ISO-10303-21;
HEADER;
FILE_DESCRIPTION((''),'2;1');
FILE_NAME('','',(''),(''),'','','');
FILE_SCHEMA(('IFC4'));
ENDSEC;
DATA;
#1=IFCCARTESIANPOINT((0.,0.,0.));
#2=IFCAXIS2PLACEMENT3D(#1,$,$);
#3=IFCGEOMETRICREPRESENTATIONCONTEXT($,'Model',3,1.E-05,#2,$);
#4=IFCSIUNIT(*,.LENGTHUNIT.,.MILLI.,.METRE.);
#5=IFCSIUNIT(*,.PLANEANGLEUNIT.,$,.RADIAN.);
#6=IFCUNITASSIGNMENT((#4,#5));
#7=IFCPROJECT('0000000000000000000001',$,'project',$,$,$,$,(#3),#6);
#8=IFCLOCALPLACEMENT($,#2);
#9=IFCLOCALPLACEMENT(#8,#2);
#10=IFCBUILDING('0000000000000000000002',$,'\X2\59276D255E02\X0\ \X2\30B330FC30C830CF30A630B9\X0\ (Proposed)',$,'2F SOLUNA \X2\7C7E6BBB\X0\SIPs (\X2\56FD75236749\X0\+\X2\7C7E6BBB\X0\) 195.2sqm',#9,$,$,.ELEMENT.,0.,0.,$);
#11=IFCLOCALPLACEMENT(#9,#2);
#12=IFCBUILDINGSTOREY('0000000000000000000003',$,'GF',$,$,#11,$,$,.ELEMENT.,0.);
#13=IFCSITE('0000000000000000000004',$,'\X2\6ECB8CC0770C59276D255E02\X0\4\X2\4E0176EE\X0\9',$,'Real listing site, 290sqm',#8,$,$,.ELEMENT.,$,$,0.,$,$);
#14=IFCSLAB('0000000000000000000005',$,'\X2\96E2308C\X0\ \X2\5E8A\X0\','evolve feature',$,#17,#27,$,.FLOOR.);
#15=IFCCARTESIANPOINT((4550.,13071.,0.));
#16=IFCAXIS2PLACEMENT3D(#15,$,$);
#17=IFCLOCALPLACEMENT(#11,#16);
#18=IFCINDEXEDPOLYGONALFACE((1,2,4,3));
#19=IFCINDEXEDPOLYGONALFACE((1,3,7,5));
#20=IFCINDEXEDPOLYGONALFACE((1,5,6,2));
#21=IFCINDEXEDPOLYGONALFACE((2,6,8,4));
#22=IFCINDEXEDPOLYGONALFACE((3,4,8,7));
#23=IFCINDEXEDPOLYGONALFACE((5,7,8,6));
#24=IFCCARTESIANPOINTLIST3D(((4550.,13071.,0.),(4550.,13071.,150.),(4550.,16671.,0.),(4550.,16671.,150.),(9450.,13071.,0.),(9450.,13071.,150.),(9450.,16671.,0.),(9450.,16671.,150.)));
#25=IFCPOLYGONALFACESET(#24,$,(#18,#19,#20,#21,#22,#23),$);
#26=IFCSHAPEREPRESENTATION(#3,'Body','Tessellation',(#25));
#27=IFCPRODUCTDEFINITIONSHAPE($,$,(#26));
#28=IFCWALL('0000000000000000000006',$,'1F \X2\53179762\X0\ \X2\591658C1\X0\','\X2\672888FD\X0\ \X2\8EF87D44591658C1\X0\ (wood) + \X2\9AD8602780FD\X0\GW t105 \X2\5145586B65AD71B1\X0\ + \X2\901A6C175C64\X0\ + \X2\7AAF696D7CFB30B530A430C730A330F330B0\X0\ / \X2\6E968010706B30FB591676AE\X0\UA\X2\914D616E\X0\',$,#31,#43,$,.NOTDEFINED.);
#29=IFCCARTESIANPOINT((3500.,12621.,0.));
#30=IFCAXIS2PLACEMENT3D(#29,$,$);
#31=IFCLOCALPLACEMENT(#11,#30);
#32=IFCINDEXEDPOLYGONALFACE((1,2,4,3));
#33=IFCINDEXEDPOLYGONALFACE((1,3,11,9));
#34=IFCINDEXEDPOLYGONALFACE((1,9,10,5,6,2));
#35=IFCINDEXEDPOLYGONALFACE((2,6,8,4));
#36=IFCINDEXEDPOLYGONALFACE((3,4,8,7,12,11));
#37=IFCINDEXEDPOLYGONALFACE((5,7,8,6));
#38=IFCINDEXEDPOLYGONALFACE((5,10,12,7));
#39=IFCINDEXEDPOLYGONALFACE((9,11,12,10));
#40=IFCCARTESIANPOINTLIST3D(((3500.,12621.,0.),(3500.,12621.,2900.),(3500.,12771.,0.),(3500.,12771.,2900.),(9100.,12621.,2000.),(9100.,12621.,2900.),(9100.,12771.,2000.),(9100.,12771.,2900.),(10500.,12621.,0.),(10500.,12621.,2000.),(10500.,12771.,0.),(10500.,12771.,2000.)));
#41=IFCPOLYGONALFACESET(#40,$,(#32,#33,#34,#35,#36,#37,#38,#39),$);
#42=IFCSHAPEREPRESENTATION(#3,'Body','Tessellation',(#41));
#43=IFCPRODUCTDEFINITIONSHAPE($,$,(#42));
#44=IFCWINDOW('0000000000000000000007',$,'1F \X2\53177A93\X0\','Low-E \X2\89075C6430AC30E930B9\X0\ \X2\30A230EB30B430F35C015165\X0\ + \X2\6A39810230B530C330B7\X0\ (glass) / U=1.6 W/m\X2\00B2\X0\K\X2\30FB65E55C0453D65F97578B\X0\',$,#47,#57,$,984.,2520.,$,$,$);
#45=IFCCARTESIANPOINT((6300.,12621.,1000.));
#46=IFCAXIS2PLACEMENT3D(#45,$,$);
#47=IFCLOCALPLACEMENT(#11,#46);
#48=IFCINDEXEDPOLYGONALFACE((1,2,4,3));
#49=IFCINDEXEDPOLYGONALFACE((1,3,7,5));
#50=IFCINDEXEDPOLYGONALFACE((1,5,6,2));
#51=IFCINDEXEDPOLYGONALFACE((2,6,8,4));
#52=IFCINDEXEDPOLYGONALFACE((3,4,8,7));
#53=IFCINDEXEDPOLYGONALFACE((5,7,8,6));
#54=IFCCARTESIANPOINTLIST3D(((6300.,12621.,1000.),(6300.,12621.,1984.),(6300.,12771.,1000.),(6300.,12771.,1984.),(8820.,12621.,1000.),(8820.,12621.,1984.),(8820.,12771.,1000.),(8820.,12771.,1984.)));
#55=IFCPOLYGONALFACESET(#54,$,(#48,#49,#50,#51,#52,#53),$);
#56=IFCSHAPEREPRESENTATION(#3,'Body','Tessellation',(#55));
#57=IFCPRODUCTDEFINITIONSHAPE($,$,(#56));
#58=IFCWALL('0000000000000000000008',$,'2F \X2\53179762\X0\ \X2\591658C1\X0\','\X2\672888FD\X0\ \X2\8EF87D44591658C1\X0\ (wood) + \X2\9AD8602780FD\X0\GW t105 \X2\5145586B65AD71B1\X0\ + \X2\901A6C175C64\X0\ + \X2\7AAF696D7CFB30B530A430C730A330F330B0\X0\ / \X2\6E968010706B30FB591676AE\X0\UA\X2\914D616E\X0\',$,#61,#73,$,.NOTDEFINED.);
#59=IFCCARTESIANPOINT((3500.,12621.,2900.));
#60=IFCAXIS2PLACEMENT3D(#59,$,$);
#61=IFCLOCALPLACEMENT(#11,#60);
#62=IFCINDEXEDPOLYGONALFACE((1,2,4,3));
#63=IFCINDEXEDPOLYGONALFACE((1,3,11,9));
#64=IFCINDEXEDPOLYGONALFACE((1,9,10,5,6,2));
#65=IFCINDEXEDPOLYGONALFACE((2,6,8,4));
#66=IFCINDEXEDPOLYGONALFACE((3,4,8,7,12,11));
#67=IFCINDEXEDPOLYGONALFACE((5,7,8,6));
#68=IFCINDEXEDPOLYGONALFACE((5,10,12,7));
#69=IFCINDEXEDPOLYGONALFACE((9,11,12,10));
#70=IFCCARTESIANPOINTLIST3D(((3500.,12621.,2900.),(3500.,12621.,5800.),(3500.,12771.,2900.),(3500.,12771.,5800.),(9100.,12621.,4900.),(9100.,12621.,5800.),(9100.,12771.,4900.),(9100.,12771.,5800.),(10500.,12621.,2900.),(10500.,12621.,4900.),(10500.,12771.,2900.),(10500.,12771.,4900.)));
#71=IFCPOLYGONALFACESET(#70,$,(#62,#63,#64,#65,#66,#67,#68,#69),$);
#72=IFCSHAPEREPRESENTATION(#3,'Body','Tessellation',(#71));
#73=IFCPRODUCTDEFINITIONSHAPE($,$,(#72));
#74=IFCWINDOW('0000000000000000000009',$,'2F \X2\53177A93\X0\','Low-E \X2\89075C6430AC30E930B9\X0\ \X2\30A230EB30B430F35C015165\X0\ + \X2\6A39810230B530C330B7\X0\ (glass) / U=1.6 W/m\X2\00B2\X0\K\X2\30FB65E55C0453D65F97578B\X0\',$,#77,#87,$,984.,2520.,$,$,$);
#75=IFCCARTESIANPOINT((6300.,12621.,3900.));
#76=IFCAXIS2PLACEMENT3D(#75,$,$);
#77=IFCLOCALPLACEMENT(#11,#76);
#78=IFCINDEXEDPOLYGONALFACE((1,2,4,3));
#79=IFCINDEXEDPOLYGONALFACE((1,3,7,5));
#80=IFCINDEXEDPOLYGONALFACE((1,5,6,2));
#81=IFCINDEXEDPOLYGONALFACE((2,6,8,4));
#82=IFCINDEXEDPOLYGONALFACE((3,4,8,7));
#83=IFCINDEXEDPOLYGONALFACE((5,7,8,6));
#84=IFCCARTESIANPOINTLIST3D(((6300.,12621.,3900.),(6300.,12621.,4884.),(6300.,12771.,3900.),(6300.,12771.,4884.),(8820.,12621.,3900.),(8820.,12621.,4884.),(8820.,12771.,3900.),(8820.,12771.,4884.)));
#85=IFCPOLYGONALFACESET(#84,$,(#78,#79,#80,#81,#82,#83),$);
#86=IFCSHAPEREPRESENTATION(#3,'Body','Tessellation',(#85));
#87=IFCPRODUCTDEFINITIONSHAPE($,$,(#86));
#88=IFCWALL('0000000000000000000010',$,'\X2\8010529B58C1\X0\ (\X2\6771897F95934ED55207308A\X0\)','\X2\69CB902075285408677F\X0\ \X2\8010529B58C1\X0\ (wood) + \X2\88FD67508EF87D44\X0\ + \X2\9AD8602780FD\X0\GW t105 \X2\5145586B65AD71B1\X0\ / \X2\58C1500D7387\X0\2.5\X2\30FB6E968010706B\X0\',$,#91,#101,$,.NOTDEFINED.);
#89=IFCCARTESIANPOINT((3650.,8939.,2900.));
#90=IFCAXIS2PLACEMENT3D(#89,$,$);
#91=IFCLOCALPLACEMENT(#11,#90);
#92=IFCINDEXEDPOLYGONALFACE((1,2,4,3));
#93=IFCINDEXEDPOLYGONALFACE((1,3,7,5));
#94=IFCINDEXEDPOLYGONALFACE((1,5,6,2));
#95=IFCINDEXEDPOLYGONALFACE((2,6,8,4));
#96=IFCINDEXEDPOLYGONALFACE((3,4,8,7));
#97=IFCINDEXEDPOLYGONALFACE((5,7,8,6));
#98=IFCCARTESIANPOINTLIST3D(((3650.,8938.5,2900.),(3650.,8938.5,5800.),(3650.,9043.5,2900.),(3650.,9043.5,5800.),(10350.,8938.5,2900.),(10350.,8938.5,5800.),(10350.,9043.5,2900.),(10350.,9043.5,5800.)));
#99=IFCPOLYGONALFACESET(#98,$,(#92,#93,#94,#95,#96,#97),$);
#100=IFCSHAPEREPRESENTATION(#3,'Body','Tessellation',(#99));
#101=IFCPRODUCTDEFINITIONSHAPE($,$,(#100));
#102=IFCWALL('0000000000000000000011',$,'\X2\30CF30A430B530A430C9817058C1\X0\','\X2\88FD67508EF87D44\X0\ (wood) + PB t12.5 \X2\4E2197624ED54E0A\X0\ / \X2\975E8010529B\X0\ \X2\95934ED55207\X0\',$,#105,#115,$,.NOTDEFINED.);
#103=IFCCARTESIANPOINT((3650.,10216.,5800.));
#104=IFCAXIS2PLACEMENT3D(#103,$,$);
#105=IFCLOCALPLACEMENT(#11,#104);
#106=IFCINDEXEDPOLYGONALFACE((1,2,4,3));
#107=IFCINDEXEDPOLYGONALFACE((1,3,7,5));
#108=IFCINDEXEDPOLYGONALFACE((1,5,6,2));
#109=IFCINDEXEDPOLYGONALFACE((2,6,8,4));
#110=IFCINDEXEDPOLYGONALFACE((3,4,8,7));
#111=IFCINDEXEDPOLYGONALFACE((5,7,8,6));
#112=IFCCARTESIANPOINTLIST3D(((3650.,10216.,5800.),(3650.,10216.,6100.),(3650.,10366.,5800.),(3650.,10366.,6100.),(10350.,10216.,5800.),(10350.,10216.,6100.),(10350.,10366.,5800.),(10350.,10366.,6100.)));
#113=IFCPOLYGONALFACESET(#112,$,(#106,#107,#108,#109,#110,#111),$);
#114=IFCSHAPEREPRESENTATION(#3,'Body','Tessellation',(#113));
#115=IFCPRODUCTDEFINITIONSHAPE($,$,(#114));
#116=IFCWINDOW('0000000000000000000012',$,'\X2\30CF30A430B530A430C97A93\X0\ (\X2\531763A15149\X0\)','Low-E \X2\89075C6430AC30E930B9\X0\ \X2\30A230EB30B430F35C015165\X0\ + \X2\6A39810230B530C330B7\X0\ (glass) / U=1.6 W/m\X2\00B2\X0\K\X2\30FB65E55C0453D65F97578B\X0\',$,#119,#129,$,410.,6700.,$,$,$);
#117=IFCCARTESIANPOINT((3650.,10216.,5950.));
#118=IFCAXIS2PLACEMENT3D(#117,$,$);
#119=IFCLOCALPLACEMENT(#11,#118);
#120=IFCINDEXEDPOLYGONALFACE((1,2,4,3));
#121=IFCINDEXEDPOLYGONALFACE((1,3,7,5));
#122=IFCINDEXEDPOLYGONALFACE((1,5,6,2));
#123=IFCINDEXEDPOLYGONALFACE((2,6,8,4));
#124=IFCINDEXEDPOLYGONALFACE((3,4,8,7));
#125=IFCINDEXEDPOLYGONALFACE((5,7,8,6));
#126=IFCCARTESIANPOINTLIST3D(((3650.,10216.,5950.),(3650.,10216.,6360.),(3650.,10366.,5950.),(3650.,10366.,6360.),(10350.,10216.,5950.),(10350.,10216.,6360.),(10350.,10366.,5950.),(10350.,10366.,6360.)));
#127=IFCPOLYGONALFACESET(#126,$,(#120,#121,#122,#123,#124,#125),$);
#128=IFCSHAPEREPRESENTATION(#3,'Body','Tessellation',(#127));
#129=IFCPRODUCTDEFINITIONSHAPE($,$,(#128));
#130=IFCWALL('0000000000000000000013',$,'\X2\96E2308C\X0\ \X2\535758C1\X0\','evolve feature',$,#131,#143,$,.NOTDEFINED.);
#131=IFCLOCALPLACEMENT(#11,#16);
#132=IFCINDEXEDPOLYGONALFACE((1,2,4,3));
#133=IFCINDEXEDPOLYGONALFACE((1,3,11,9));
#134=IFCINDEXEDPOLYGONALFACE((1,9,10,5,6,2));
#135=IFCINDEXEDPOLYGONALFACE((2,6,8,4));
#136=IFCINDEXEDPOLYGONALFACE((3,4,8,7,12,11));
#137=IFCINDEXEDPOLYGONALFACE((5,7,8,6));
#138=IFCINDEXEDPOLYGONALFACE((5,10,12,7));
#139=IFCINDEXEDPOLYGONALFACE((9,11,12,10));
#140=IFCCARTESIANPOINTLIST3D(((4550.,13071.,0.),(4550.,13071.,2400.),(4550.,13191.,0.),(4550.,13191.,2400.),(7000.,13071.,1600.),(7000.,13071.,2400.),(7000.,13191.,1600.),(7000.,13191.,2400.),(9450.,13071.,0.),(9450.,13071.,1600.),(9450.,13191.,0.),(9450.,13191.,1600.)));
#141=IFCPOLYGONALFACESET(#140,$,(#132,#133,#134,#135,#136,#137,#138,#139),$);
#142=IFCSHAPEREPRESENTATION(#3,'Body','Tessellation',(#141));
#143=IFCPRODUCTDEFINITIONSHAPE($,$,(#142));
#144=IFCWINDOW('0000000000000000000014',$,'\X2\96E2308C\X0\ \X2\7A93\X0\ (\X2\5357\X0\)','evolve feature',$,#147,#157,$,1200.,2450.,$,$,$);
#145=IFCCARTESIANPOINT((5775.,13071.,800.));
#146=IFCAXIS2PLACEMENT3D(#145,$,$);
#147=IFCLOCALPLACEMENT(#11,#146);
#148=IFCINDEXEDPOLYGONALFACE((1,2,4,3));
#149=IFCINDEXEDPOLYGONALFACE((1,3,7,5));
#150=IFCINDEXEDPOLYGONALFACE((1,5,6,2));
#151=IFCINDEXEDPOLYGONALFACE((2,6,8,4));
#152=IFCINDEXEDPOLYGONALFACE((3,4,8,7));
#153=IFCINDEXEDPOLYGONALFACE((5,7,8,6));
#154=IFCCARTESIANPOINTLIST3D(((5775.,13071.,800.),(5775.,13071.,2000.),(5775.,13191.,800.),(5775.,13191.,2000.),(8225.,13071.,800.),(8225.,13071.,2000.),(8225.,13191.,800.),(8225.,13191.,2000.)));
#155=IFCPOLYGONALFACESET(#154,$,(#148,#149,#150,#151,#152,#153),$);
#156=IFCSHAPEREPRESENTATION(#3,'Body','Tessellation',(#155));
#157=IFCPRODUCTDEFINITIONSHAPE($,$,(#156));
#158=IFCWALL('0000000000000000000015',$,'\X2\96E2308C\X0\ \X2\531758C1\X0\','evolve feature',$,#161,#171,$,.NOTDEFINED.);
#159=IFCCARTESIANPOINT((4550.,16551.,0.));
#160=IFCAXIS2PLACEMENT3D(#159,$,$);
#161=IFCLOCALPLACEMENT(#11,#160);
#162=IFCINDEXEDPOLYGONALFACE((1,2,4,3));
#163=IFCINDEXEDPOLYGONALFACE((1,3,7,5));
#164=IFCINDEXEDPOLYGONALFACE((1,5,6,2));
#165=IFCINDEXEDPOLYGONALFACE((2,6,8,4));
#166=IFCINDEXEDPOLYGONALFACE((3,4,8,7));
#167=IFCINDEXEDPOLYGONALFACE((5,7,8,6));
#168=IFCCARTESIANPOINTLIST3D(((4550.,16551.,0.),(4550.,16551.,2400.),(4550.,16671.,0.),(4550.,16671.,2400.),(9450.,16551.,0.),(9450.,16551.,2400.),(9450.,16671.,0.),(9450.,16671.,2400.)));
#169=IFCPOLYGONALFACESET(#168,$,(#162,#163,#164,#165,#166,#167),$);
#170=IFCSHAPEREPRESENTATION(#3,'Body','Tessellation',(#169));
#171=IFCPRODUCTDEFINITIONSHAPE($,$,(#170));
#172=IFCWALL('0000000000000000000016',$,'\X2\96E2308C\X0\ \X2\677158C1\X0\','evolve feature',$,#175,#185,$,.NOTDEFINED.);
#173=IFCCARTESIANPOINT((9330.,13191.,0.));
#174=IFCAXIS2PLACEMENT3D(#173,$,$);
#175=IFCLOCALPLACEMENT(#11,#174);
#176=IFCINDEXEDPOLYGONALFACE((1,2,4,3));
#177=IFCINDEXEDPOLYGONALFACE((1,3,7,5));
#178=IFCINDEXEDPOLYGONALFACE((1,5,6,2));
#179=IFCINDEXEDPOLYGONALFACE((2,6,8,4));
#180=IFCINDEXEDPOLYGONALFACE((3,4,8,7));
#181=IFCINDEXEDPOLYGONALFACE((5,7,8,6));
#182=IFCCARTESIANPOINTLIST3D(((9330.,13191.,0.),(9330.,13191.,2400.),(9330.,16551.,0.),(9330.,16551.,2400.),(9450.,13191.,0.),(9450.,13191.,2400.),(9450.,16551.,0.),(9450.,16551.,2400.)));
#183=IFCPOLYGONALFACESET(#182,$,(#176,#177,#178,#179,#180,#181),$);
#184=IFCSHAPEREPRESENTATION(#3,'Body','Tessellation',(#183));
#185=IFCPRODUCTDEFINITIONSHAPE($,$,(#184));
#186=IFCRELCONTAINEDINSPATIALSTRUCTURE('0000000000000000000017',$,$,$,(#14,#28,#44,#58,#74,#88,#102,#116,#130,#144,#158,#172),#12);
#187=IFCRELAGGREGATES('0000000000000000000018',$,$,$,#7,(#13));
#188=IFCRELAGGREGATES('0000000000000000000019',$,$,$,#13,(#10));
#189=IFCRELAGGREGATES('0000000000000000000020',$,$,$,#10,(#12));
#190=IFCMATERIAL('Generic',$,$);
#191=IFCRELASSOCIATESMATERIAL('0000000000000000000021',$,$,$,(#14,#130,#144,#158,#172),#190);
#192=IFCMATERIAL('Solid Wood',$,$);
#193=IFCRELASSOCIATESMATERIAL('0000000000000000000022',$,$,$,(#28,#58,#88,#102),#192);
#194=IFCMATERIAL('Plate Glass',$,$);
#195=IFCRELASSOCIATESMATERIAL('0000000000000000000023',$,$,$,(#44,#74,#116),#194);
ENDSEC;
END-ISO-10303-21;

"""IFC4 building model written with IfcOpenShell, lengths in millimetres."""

from ifc_helpers import new_model, si_unit, frame, frame_2d, origin, place, context, project, spatial, rectangle, extrude, material, element, fill, save


model = new_model("IFC4")

# Units and contexts
model_context = context("Model", 3, precision=1e-05, world=origin())
ifc_project = project(units=[si_unit("LENGTHUNIT", "METRE", prefix="MILLI"), si_unit("PLANEANGLEUNIT", "RADIAN")], contexts=[model_context])

# Site, building, storey
site_placement = place(None, origin())
site = spatial("IfcSite", under=ifc_project, at=site_placement, Name="滋賀県大津市4丁目9", ObjectType="Real listing site, 290sqm", CompositionType="ELEMENT", RefElevation=0.0)
building_placement = place(site_placement, origin())
building = spatial("IfcBuilding", under=site, at=building_placement, Name="大津市 コートハウス (Proposed)", ObjectType="2F SOLUNA 籾殻SIPs (国産杉+籾殻) 195.2sqm", CompositionType="ELEMENT", ElevationOfRefHeight=0.0, ElevationOfTerrain=0.0)
storey_placement = place(building_placement, origin())
storey = spatial("IfcBuildingStorey", under=building, at=storey_placement, Name="GF", CompositionType="ELEMENT", Elevation=0.0)

# Slab
ifc_material_1 = material(Name="Generic")
slab_placement = place(storey_placement, frame((4550.0, 13071.0, 0.0)))
element("IfcSlab", 1, at=slab_placement, inside=storey, material=ifc_material_1, Name="離れ 床", Description="evolve feature", PredefinedType="FLOOR", context=model_context, shape_type="SweptSolid", body=[
    extrude(rectangle(XDim=4900.0, YDim=3600.0, at=frame_2d((2450.0, 1800.0))), frame((4550.0, 13071.0, 0.0)), (0.0, 0.0, 1.0), 150.0),
])

# Wall, opening, window
ifc_material_2 = material(Name="Solid Wood")
wall_1_placement = place(storey_placement, frame((3500.0, 12621.0, 0.0)))
wall_1 = element("IfcWall", 2, at=wall_1_placement, inside=storey, material=ifc_material_2, Name="1F 北面 外壁", Description="木製 軸組外壁 (wood) + 高性能GW t105 充填断熱 + 通気層 + 窯業系サイディング / 準耐火・外皮UA配慮", PredefinedType="NOTDEFINED", context=model_context, shape_type="SweptSolid", body=[
    extrude(rectangle(XDim=7000.0, YDim=150.0, at=frame_2d((3500.0, 75.0))), frame((3500.0, 12621.0, 0.0)), (0.0, 0.0, 1.0), 2900.0),
])
opening_1_placement = place(storey_placement, frame((6300.0, 12621.0, 1000.0)))
opening_1 = element("IfcOpeningElement", 3, at=opening_1_placement, cuts=wall_1, PredefinedType="NOTDEFINED", context=model_context, shape_type="SweptSolid", body=[
    extrude(rectangle(XDim=2520.0, YDim=150.0, at=frame_2d((1260.0, 75.0))), frame((6300.0, 12621.0, 1000.0)), (0.0, 0.0, 1.0), 984.0),
])
ifc_material_3 = material(Name="Plate Glass")
window_1_placement = place(storey_placement, frame((6300.0, 12621.0, 1000.0)))
window_1 = element("IfcWindow", 4, at=window_1_placement, inside=storey, material=ifc_material_3, Name="1F 北窓", Description="Low-E 複層ガラス アルゴン封入 + 樹脂サッシ (glass) / U=1.6 W/m²K・日射取得型", OverallHeight=984.0, OverallWidth=2520.0, context=model_context, shape_type="SweptSolid", body=[
    extrude(rectangle(XDim=2520.0, YDim=150.0, at=frame_2d((1260.0, 75.0))), frame((6300.0, 12621.0, 1000.0)), (0.0, 0.0, 1.0), 984.0),
])
fill(opening_1, window_1)

# Wall, opening, window
wall_2_placement = place(storey_placement, frame((3500.0, 12621.0, 2900.0)))
wall_2 = element("IfcWall", 5, at=wall_2_placement, inside=storey, material=ifc_material_2, Name="2F 北面 外壁", Description="木製 軸組外壁 (wood) + 高性能GW t105 充填断熱 + 通気層 + 窯業系サイディング / 準耐火・外皮UA配慮", PredefinedType="NOTDEFINED", context=model_context, shape_type="SweptSolid", body=[
    extrude(rectangle(XDim=7000.0, YDim=150.0, at=frame_2d((3500.0, 75.0))), frame((3500.0, 12621.0, 2900.0)), (0.0, 0.0, 1.0), 2900.0),
])
opening_2_placement = place(storey_placement, frame((6300.0, 12621.0, 3900.0)))
opening_2 = element("IfcOpeningElement", 6, at=opening_2_placement, cuts=wall_2, PredefinedType="NOTDEFINED", context=model_context, shape_type="SweptSolid", body=[
    extrude(rectangle(XDim=2520.0, YDim=150.0, at=frame_2d((1260.0, 75.0))), frame((6300.0, 12621.0, 3900.0)), (0.0, 0.0, 1.0), 984.0),
])
window_2_placement = place(storey_placement, frame((6300.0, 12621.0, 3900.0)))
window_2 = element("IfcWindow", 7, at=window_2_placement, inside=storey, material=ifc_material_3, Name="2F 北窓", Description="Low-E 複層ガラス アルゴン封入 + 樹脂サッシ (glass) / U=1.6 W/m²K・日射取得型", OverallHeight=984.0, OverallWidth=2520.0, context=model_context, shape_type="SweptSolid", body=[
    extrude(rectangle(XDim=2520.0, YDim=150.0, at=frame_2d((1260.0, 75.0))), frame((6300.0, 12621.0, 3900.0)), (0.0, 0.0, 1.0), 984.0),
])
fill(opening_2, window_2)

# Wall
wall_3_placement = place(storey_placement, frame((3650.0, 8939.0, 2900.0)))
element("IfcWall", 8, at=wall_3_placement, inside=storey, material=ifc_material_2, Name="耐力壁 (東西間仕切り)", Description="構造用合板 耐力壁 (wood) + 製材軸組 + 高性能GW t105 充填断熱 / 壁倍率2.5・準耐火", PredefinedType="NOTDEFINED", context=model_context, shape_type="SweptSolid", body=[
    extrude(rectangle(XDim=6700.0, YDim=105.0, at=frame_2d((3350.0, 52.0))), frame((3650.0, 8939.0, 2900.0)), (0.0, 0.0, 1.0), 2900.0),
])

# Walls, openings, windows
wall_4_placement = place(storey_placement, frame((3650.0, 10216.0, 5800.0)))
wall_4 = element("IfcWall", 9, at=wall_4_placement, inside=storey, material=ifc_material_2, Name="ハイサイド腰壁", Description="製材軸組 (wood) + PB t12.5 両面仕上 / 非耐力 間仕切", PredefinedType="NOTDEFINED", context=model_context, shape_type="SweptSolid", body=[
    extrude(rectangle(XDim=6700.0, YDim=150.0, at=frame_2d((3350.0, 75.0))), frame((3650.0, 10216.0, 5800.0)), (0.0, 0.0, 1.0), 700.0),
])
opening_3_placement = place(storey_placement, frame((3650.0, 10216.0, 5950.0)))
opening_3 = element("IfcOpeningElement", 10, at=opening_3_placement, cuts=wall_4, PredefinedType="NOTDEFINED", context=model_context, shape_type="SweptSolid", body=[
    extrude(rectangle(XDim=6700.0, YDim=150.0, at=frame_2d((3350.0, 75.0))), frame((3650.0, 10216.0, 5950.0)), (0.0, 0.0, 1.0), 410.0),
])
window_3_placement = place(storey_placement, frame((3650.0, 10216.0, 5950.0)))
window_3 = element("IfcWindow", 11, at=window_3_placement, inside=storey, material=ifc_material_3, Name="ハイサイド窓 (北採光)", Description="Low-E 複層ガラス アルゴン封入 + 樹脂サッシ (glass) / U=1.6 W/m²K・日射取得型", OverallHeight=410.0, OverallWidth=6700.0, context=model_context, shape_type="SweptSolid", body=[
    extrude(rectangle(XDim=6700.0, YDim=150.0, at=frame_2d((3350.0, 75.0))), frame((3650.0, 10216.0, 5950.0)), (0.0, 0.0, 1.0), 410.0),
])
fill(opening_3, window_3)
wall_5_placement = place(storey_placement, frame((4550.0, 13071.0, 0.0)))
wall_5 = element("IfcWall", 12, at=wall_5_placement, inside=storey, material=ifc_material_1, Name="離れ 南壁", Description="evolve feature", PredefinedType="NOTDEFINED", context=model_context, shape_type="SweptSolid", body=[
    extrude(rectangle(XDim=4900.0, YDim=120.0, at=frame_2d((2450.0, 60.0))), frame((4550.0, 13071.0, 0.0)), (0.0, 0.0, 1.0), 2400.0),
])
opening_4_placement = place(storey_placement, frame((5775.0, 13071.0, 800.0)))
opening_4 = element("IfcOpeningElement", 13, at=opening_4_placement, cuts=wall_5, PredefinedType="NOTDEFINED", context=model_context, shape_type="SweptSolid", body=[
    extrude(rectangle(XDim=2450.0, YDim=120.0, at=frame_2d((1225.0, 60.0))), frame((5775.0, 13071.0, 800.0)), (0.0, 0.0, 1.0), 1200.0),
])
window_4_placement = place(storey_placement, frame((5775.0, 13071.0, 800.0)))
window_4 = element("IfcWindow", 14, at=window_4_placement, inside=storey, material=ifc_material_1, Name="離れ 窓 (南)", Description="evolve feature", OverallHeight=1200.0, OverallWidth=2450.0, context=model_context, shape_type="SweptSolid", body=[
    extrude(rectangle(XDim=2450.0, YDim=120.0, at=frame_2d((1225.0, 60.0))), frame((5775.0, 13071.0, 800.0)), (0.0, 0.0, 1.0), 1200.0),
])
fill(opening_4, window_4)

# Walls
wall_6_placement = place(storey_placement, frame((4550.0, 16551.0, 0.0)))
element("IfcWall", 15, at=wall_6_placement, inside=storey, material=ifc_material_1, Name="離れ 北壁", Description="evolve feature", PredefinedType="NOTDEFINED", context=model_context, shape_type="SweptSolid", body=[
    extrude(rectangle(XDim=4900.0, YDim=120.0, at=frame_2d((2450.0, 60.0))), frame((4550.0, 16551.0, 0.0)), (0.0, 0.0, 1.0), 2400.0),
])
wall_7_placement = place(storey_placement, frame((9330.0, 13191.0, 0.0)))
element("IfcWall", 16, at=wall_7_placement, inside=storey, material=ifc_material_1, Name="離れ 東壁", Description="evolve feature", PredefinedType="NOTDEFINED", context=model_context, shape_type="SweptSolid", body=[
    extrude(rectangle(XDim=120.0, YDim=3360.0, at=frame_2d((60.0, 1680.0))), frame((9330.0, 13191.0, 0.0)), (0.0, 0.0, 1.0), 2400.0),
])

save(model, "model.ifc")
